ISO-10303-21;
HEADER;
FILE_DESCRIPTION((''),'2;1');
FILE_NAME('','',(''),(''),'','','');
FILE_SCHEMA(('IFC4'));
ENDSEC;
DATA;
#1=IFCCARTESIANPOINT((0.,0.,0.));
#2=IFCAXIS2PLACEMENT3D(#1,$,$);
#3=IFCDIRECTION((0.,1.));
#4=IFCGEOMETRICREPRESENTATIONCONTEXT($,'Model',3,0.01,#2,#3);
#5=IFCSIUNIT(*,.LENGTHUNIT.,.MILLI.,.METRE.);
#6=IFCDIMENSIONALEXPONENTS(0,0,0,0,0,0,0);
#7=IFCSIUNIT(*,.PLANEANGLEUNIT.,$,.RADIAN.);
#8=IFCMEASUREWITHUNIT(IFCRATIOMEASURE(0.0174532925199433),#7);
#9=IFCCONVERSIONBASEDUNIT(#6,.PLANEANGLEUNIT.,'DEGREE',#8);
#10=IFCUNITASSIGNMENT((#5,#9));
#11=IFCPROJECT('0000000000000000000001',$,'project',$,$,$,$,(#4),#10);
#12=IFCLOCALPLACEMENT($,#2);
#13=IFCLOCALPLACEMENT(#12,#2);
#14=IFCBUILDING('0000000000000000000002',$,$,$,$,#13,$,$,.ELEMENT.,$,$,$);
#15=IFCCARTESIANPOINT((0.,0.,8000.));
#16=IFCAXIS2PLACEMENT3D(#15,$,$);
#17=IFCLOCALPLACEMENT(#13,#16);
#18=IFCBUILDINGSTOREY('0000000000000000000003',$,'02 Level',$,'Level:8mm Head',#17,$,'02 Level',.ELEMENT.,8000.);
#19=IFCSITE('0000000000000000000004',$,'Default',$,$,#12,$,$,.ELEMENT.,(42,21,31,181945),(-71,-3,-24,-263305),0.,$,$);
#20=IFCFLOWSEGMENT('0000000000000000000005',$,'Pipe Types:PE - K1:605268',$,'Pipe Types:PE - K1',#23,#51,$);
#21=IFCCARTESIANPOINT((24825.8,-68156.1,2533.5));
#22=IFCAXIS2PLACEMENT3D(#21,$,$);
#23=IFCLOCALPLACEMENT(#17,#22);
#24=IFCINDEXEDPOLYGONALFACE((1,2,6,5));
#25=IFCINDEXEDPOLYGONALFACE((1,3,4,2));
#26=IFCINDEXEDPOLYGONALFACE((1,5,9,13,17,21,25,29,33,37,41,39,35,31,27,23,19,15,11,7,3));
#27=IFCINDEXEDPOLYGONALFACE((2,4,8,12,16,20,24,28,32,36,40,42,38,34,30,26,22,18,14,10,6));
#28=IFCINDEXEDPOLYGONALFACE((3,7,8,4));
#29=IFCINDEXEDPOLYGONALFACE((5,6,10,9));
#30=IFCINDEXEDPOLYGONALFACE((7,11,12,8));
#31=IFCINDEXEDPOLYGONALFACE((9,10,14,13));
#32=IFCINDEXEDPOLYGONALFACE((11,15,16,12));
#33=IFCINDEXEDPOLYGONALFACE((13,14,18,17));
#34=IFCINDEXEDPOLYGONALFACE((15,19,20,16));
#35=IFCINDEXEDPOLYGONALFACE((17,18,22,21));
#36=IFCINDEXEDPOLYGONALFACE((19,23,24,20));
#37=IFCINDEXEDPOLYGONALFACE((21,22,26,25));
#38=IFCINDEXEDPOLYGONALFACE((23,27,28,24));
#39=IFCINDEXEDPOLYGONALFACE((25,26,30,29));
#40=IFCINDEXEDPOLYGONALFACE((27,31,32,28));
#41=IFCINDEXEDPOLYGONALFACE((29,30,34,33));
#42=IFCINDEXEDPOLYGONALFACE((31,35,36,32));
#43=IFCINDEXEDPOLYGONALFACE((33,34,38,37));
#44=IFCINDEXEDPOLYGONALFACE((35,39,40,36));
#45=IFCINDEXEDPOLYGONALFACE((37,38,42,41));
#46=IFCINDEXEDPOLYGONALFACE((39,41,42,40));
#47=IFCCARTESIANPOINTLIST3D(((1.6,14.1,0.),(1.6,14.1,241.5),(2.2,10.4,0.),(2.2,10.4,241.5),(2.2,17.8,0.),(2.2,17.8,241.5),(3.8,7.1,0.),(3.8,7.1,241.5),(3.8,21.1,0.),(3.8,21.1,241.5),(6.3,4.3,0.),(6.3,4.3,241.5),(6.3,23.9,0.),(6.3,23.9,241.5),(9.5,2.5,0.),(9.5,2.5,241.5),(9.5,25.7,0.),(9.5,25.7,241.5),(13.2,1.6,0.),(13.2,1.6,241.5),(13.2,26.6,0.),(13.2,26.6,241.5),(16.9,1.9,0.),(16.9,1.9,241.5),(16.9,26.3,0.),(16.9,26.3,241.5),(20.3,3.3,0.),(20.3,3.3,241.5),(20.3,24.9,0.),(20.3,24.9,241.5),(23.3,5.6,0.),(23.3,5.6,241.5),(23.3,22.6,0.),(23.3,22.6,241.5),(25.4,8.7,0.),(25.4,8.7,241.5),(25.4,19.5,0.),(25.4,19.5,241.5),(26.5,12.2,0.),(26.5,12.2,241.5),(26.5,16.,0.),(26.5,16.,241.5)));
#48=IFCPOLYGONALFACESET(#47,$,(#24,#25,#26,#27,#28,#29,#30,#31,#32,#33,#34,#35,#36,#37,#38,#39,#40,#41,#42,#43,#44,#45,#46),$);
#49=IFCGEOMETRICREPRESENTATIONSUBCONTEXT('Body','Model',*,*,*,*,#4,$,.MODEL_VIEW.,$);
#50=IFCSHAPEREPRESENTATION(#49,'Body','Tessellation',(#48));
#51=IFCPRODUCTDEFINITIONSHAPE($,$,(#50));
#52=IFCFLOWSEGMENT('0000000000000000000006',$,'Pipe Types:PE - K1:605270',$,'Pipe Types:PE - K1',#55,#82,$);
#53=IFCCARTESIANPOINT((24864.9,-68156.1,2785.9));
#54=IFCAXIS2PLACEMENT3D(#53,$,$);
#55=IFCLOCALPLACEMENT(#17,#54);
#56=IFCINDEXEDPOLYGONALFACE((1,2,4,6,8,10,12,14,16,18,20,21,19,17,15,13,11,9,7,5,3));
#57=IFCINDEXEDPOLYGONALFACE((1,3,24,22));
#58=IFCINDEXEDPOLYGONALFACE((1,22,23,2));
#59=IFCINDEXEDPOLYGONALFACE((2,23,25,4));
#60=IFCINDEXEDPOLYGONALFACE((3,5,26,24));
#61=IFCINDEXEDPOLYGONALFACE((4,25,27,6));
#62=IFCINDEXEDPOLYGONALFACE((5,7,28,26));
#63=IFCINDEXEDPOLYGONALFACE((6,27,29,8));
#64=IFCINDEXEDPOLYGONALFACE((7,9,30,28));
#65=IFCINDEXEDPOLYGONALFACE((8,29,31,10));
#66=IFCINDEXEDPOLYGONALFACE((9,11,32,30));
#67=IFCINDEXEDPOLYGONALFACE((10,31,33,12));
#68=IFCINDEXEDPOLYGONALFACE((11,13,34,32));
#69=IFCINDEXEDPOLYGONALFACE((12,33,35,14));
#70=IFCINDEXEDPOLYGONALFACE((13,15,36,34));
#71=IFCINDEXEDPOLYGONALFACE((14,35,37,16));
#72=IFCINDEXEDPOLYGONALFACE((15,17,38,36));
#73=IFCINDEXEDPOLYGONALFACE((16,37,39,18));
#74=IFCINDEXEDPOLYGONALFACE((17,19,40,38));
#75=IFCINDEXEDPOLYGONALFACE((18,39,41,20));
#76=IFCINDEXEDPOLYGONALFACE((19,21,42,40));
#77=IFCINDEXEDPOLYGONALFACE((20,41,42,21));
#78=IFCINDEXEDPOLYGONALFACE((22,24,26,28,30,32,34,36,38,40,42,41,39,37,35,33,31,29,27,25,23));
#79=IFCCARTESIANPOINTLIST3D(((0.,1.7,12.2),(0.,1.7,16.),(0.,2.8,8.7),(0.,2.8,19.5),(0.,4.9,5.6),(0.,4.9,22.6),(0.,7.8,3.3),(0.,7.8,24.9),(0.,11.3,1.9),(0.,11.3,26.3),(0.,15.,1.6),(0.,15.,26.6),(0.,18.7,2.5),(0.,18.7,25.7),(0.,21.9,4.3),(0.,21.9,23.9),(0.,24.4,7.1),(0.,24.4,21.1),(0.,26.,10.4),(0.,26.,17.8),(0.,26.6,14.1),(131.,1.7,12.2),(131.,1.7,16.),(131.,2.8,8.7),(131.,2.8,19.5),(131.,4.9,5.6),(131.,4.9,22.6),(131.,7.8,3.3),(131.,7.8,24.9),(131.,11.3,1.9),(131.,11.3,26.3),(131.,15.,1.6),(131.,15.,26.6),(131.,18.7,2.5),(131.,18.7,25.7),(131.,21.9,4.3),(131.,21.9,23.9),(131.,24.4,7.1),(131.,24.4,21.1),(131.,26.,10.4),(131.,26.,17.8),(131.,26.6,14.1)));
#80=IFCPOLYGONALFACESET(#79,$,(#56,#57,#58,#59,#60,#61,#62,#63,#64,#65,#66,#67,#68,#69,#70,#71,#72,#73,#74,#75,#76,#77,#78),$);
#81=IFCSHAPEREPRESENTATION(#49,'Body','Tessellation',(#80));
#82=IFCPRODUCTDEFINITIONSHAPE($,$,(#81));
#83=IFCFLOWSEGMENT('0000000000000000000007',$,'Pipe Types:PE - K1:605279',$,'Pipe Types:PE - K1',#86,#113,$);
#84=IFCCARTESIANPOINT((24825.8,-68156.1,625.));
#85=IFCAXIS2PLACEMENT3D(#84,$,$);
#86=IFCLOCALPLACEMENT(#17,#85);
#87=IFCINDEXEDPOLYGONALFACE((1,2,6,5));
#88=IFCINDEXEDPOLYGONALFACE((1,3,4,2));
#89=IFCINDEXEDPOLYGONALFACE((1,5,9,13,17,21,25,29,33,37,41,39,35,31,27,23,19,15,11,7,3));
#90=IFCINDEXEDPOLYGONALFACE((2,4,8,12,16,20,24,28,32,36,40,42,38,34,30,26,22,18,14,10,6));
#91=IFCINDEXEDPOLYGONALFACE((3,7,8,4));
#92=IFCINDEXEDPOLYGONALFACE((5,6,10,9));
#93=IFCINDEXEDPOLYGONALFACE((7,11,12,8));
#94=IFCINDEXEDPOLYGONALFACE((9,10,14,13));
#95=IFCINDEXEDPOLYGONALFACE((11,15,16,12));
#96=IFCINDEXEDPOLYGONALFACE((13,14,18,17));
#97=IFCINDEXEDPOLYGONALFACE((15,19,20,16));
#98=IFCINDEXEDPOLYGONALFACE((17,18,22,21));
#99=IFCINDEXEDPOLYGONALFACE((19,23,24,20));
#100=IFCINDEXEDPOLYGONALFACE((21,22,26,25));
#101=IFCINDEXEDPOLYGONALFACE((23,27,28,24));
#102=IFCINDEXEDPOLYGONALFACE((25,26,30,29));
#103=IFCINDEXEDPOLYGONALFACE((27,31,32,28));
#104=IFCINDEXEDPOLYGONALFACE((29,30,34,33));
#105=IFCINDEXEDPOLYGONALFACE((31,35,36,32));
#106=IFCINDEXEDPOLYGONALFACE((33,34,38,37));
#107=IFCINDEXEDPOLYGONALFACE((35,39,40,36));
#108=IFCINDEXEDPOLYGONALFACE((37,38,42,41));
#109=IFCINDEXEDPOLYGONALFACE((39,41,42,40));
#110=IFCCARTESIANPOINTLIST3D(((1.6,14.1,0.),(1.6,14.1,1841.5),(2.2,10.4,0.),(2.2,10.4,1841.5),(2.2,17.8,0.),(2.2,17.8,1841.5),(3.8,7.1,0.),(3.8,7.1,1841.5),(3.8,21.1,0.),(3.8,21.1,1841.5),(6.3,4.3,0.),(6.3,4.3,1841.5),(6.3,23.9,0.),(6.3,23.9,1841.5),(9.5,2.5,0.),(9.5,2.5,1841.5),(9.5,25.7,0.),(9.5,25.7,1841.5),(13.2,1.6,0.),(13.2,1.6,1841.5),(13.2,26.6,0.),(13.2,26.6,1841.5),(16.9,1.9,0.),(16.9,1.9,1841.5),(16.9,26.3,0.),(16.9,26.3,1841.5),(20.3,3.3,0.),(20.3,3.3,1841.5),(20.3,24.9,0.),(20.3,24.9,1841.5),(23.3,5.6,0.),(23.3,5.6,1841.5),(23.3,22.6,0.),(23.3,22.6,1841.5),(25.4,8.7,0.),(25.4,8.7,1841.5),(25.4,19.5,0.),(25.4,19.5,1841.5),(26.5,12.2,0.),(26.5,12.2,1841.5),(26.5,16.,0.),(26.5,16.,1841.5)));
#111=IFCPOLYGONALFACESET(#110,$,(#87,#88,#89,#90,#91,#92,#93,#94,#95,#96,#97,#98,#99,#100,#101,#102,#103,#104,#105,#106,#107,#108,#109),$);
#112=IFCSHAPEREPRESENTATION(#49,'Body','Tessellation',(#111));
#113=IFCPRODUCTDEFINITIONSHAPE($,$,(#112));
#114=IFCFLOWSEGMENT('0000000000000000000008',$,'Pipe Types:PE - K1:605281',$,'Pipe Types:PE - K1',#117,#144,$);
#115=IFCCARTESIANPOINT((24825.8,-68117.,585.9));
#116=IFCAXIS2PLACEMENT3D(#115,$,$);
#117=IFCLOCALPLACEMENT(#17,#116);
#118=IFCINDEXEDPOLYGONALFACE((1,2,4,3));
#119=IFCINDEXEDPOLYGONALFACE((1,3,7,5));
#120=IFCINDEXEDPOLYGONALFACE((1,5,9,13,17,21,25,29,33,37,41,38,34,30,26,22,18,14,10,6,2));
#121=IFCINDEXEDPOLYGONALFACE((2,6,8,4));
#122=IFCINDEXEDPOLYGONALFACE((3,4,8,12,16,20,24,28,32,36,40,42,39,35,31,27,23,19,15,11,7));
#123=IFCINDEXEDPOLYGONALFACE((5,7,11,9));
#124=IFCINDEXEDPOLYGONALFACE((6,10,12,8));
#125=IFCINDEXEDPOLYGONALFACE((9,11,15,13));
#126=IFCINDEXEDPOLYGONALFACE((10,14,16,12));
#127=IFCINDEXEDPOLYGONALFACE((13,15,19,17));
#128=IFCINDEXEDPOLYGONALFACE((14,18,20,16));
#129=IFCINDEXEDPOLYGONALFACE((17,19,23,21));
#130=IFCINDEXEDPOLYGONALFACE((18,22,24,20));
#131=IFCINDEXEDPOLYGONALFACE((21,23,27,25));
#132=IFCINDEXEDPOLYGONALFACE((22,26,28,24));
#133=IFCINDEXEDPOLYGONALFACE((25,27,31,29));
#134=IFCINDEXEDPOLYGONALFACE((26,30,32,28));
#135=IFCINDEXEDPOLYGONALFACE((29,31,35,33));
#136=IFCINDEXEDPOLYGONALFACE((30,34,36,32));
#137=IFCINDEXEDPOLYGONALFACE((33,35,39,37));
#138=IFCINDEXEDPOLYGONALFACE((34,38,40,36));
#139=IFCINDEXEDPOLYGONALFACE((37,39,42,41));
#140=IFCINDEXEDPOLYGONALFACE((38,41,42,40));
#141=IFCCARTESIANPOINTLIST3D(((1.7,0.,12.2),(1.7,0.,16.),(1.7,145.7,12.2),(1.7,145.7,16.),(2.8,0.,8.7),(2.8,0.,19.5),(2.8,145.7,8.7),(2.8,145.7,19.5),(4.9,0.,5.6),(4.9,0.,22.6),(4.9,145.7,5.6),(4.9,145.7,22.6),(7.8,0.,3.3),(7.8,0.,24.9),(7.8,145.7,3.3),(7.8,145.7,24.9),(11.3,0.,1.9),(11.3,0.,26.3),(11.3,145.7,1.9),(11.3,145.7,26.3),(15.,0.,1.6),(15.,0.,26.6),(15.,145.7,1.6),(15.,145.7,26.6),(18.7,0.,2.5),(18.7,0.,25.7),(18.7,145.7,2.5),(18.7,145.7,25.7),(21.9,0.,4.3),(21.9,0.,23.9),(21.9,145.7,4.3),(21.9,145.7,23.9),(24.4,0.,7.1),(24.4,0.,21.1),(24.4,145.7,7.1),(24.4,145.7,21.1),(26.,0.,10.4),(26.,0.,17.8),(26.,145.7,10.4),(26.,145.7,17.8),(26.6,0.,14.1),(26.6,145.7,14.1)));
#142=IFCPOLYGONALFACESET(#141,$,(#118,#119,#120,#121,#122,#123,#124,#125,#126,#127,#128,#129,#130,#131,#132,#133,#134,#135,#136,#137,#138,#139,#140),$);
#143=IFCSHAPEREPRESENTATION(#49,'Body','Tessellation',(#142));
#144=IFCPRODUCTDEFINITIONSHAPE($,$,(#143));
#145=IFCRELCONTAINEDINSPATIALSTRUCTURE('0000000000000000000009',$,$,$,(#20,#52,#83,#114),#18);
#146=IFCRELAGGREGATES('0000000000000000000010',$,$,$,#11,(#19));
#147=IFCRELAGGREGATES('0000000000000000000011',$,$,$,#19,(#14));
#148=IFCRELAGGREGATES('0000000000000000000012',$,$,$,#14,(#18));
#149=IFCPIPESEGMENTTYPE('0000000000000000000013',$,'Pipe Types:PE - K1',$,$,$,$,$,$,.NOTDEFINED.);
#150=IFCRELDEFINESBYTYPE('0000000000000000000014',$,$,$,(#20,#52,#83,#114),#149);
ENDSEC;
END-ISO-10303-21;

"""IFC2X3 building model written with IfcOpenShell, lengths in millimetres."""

from ifc_helpers import new_model, entity, si_unit, converted_unit, direction, frame, origin, origin_2d_with_axis, place, context, subcontext, project, spatial, circle, extrude, type_object, element, save


model = new_model("IFC2X3")

# Units and contexts
model_context = context("Model", 3, precision=0.01, world=origin(), true_north=direction((0.0, 1.0)))
body_context = subcontext(model_context, "Body", "Model", "MODEL_VIEW")
ifc_project = project(units=[si_unit("LENGTHUNIT", "METRE", prefix="MILLI"), converted_unit("PLANEANGLEUNIT", "DEGREE", entity("IfcRatioMeasure", 0.0174532925199433), si_unit("PLANEANGLEUNIT", "RADIAN"), dimensions=[0, 0, 0, 0, 0, 0, 0])], contexts=[model_context])

# Site, building, storey
site_placement = place(None, origin())
site = spatial("IfcSite", under=ifc_project, at=site_placement, Name="Default", CompositionType="ELEMENT", RefLatitude=(42, 21, 31, 181945), RefLongitude=(-71, -3, -24, -263305), RefElevation=0.0)
building_placement = place(site_placement, origin())
building = spatial("IfcBuilding", under=site, at=building_placement, CompositionType="ELEMENT")
storey_placement = place(building_placement, frame((0.0, 0.0, 8000.0)))
storey = spatial("IfcBuildingStorey", under=building, at=storey_placement, Name="02 Level", ObjectType="Level:8mm Head", LongName="02 Level", CompositionType="ELEMENT", Elevation=8000.0)

# Flow segments
pipe_segment_type = type_object("IfcPipeSegmentType", Name="Pipe Types:PE - K1", PredefinedType="NOTDEFINED")
flow_segment_1_placement = place(storey_placement, frame((24825.8, -68156.1, 2533.5)))
element("IfcFlowSegment", 1, at=flow_segment_1_placement, inside=storey, type_object=pipe_segment_type, Name="Pipe Types:PE - K1:605268", ObjectType="Pipe Types:PE - K1", context=body_context, shape_type="SweptSolid", body=[
    extrude(circle(Radius=12.5, at=origin_2d_with_axis()), frame((14.1, 14.1, 0.0), z_axis=(0.0, 0.0, 1.0), x_axis=(-1.0, 0.0, 0.0)), (0.0, 0.0, 1.0), 241.5),
])
flow_segment_2_placement = place(storey_placement, frame((24864.9, -68156.1, 2785.9)))
element("IfcFlowSegment", 2, at=flow_segment_2_placement, inside=storey, type_object=pipe_segment_type, Name="Pipe Types:PE - K1:605270", ObjectType="Pipe Types:PE - K1", context=body_context, shape_type="SweptSolid", body=[
    extrude(circle(Radius=12.5, at=origin_2d_with_axis()), frame((0.0, 14.1, 14.1), z_axis=(1.0, 0.0, 0.0), x_axis=(0.0, 1.0, 0.0)), (0.0, 0.0, 1.0), 131.0),
])
flow_segment_3_placement = place(storey_placement, frame((24825.8, -68156.1, 625.0)))
element("IfcFlowSegment", 3, at=flow_segment_3_placement, inside=storey, type_object=pipe_segment_type, Name="Pipe Types:PE - K1:605279", ObjectType="Pipe Types:PE - K1", context=body_context, shape_type="SweptSolid", body=[
    extrude(circle(Radius=12.5, at=origin_2d_with_axis()), frame((14.1, 14.1, 0.0), z_axis=(0.0, 0.0, 1.0), x_axis=(-1.0, 0.0, 0.0)), (0.0, 0.0, 1.0), 1841.5),
])
flow_segment_4_placement = place(storey_placement, frame((24825.8, -68117.0, 585.9)))
element("IfcFlowSegment", 4, at=flow_segment_4_placement, inside=storey, type_object=pipe_segment_type, Name="Pipe Types:PE - K1:605281", ObjectType="Pipe Types:PE - K1", context=body_context, shape_type="SweptSolid", body=[
    extrude(circle(Radius=12.5, at=origin_2d_with_axis()), frame((14.1, 0.0, 14.1), z_axis=(0.0, 1.0, 0.0), x_axis=(1.0, 0.0, 0.0)), (0.0, 0.0, 1.0), 145.7),
])

save(model, "model.ifc")
